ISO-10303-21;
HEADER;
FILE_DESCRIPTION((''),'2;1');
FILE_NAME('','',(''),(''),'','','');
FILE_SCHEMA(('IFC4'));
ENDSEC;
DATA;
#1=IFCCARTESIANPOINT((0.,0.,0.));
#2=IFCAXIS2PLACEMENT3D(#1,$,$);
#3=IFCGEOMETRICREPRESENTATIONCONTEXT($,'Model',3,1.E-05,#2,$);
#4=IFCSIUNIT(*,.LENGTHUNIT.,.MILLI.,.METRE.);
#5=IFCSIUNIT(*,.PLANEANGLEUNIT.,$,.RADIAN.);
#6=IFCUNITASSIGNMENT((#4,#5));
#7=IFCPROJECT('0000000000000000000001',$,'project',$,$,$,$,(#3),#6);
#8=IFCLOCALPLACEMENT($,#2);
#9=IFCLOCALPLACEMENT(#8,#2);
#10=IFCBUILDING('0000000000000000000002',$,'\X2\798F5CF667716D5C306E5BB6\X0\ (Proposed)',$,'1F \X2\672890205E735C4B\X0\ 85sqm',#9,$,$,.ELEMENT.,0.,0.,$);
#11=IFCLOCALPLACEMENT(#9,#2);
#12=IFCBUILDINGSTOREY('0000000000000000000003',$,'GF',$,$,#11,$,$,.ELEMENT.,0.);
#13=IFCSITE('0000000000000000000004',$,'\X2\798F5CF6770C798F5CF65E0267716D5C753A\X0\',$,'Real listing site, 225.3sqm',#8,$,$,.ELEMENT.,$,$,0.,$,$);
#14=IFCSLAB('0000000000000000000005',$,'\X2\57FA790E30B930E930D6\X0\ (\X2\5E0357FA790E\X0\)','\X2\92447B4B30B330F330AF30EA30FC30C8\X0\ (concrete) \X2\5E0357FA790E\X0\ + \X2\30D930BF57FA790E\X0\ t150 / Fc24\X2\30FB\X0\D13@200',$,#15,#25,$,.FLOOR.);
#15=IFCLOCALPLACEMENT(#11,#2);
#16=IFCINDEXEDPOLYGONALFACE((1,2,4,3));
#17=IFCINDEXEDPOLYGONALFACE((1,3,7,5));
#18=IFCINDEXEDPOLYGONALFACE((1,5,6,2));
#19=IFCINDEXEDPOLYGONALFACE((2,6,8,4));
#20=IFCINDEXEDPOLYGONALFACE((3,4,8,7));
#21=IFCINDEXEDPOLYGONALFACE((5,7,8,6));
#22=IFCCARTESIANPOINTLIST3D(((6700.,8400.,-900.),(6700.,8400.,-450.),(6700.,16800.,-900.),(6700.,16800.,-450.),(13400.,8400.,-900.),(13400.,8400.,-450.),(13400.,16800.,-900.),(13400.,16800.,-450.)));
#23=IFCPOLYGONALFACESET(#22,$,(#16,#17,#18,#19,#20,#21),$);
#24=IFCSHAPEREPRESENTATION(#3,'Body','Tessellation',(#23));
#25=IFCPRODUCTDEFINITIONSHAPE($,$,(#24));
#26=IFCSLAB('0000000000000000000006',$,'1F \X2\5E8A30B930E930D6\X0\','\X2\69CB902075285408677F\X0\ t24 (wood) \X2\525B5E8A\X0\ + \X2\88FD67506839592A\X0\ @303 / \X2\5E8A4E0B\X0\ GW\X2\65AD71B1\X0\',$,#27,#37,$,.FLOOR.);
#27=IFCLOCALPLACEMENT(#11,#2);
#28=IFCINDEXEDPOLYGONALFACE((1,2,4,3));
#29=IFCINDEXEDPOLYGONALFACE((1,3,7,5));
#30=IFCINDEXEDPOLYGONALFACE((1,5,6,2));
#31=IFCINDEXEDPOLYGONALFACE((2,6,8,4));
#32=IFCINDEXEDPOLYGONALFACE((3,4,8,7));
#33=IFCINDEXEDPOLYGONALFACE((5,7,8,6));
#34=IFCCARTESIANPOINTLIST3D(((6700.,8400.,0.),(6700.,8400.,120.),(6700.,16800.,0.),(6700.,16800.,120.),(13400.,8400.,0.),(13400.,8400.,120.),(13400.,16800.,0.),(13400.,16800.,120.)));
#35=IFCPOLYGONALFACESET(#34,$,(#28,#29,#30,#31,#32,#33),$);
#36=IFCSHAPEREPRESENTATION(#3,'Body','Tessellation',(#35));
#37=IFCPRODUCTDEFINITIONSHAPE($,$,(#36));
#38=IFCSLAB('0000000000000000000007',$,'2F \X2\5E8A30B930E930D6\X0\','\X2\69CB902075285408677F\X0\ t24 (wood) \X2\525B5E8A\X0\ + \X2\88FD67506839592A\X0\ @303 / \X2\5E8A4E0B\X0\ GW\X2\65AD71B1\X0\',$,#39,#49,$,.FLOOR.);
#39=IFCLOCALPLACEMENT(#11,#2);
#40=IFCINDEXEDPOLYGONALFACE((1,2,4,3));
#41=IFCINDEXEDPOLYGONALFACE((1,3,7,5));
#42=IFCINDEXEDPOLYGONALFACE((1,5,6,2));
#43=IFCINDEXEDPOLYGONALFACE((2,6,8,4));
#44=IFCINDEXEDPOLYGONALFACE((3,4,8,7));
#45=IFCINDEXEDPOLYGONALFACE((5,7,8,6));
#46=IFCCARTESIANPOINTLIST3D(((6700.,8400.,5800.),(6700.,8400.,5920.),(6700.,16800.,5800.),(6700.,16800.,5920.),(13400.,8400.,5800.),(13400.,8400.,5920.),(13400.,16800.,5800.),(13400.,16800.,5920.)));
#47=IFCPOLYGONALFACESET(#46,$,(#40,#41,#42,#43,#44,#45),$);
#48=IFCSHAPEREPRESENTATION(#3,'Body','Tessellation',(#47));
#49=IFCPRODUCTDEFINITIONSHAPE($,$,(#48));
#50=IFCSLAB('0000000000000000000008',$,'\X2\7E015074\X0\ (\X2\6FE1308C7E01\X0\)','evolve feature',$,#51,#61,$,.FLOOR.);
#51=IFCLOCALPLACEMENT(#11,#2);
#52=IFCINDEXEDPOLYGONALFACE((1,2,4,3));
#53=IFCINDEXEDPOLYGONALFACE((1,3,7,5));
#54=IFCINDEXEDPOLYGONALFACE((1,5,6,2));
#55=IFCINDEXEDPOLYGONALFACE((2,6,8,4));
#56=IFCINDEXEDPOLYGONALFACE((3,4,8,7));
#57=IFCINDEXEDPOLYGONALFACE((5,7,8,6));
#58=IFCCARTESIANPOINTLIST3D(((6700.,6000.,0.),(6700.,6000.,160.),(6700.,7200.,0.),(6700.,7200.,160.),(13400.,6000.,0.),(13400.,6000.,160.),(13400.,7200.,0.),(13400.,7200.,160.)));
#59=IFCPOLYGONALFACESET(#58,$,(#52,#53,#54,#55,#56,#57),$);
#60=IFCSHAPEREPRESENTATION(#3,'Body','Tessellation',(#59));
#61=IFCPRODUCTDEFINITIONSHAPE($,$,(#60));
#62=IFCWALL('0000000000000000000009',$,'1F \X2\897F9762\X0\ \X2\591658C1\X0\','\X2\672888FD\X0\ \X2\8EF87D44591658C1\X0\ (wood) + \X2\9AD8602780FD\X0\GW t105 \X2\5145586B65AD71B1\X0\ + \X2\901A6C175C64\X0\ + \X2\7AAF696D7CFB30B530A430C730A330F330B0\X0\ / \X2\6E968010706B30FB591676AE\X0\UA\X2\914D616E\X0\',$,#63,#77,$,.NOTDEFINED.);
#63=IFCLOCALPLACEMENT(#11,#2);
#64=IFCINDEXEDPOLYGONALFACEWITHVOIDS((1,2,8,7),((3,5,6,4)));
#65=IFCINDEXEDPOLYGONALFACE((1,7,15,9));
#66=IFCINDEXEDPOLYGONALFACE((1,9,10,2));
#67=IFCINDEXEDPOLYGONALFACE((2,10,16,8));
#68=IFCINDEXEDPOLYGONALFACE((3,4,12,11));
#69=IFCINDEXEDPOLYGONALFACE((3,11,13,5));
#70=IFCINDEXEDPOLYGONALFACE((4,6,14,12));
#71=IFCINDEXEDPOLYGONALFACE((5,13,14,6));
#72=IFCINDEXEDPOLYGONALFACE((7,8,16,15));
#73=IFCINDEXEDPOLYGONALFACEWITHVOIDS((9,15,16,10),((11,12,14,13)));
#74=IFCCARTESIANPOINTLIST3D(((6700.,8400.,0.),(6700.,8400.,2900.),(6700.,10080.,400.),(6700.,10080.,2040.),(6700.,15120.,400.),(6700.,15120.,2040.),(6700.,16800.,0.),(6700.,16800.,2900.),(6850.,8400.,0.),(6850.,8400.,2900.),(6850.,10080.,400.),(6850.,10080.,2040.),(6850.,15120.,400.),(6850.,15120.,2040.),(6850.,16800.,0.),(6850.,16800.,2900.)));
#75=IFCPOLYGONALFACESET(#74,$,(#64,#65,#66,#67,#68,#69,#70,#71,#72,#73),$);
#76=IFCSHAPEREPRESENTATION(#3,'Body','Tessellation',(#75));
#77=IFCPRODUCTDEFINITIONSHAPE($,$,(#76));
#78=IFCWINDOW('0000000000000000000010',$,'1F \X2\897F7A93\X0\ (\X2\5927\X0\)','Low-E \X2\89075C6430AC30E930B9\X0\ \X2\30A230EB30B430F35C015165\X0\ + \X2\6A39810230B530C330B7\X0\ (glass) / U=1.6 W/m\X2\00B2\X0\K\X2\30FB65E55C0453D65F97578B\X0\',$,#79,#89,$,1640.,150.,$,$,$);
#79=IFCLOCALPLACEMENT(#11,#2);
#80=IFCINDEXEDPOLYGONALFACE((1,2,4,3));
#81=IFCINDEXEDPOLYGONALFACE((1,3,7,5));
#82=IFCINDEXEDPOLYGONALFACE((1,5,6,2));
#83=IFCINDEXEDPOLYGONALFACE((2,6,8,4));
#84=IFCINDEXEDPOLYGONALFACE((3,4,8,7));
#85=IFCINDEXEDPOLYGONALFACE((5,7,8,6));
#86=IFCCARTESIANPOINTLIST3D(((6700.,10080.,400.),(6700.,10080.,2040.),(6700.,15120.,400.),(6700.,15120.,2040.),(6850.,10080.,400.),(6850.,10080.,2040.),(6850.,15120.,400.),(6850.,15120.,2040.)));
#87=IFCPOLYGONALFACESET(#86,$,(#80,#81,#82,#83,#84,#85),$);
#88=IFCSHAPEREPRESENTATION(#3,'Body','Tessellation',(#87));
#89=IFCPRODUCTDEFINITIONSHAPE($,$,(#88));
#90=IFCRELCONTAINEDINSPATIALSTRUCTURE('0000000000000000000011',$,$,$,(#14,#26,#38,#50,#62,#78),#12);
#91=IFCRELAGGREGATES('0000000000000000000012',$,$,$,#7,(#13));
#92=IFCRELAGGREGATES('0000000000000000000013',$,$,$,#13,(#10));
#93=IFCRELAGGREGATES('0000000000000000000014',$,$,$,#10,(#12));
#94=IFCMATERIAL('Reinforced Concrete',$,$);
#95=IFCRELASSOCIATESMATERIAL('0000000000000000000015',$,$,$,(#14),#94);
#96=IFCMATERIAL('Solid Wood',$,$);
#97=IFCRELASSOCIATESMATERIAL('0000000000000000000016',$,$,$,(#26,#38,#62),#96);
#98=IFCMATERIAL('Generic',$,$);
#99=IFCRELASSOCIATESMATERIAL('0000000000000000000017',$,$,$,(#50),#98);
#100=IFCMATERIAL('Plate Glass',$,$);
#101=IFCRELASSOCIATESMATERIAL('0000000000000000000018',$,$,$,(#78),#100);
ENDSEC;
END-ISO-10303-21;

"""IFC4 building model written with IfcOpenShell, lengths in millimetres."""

from ifc_helpers import new_model, si_unit, frame, frame_2d, origin, place, context, project, spatial, rectangle, extrude, material, element, fill, save


model = new_model("IFC4")

# Units and contexts
model_context = context("Model", 3, precision=1e-05, world=origin())
ifc_project = project(units=[si_unit("LENGTHUNIT", "METRE", prefix="MILLI"), si_unit("PLANEANGLEUNIT", "RADIAN")], contexts=[model_context])

# Site, building, storey
site_placement = place(None, origin())
site = spatial("IfcSite", under=ifc_project, at=site_placement, Name="福島県福島市東浜町", ObjectType="Real listing site, 225.3sqm", CompositionType="ELEMENT", RefElevation=0.0)
building_placement = place(site_placement, origin())
building = spatial("IfcBuilding", under=site, at=building_placement, Name="福島東浜の家 (Proposed)", ObjectType="1F 木造平屋 85sqm", CompositionType="ELEMENT", ElevationOfRefHeight=0.0, ElevationOfTerrain=0.0)
storey_placement = place(building_placement, origin())
storey = spatial("IfcBuildingStorey", under=building, at=storey_placement, Name="GF", CompositionType="ELEMENT", Elevation=0.0)

# Slabs
ifc_material_1 = material(Name="Reinforced Concrete")
slab_1_placement = place(storey_placement, frame((3350.0, 4200.0, -450.0)))
element("IfcSlab", 1, at=slab_1_placement, inside=storey, material=ifc_material_1, Name="基礎スラブ (布基礎)", Description="鉄筋コンクリート (concrete) 布基礎 + ベタ基礎 t150 / Fc24・D13@200", PredefinedType="FLOOR", context=model_context, shape_type="SweptSolid", body=[
    extrude(rectangle(XDim=6700.0, YDim=8400.0, at=frame_2d((3350.0, 4200.0))), frame((3350.0, 4200.0, -450.0)), (0.0, 0.0, 1.0), 450.0),
])
ifc_material_2 = material(Name="Solid Wood")
slab_2_placement = place(storey_placement, frame((3350.0, 4200.0, 0.0)))
element("IfcSlab", 2, at=slab_2_placement, inside=storey, material=ifc_material_2, Name="1F 床スラブ", Description="構造用合板 t24 (wood) 剛床 + 製材根太 @303 / 床下 GW断熱", PredefinedType="FLOOR", context=model_context, shape_type="SweptSolid", body=[
    extrude(rectangle(XDim=6700.0, YDim=8400.0, at=frame_2d((3350.0, 4200.0))), frame((3350.0, 4200.0, 0.0)), (0.0, 0.0, 1.0), 120.0),
])
slab_3_placement = place(storey_placement, frame((3350.0, 4200.0, 2900.0)))
element("IfcSlab", 3, at=slab_3_placement, inside=storey, material=ifc_material_2, Name="2F 床スラブ", Description="構造用合板 t24 (wood) 剛床 + 製材根太 @303 / 床下 GW断熱", PredefinedType="FLOOR", context=model_context, shape_type="SweptSolid", body=[
    extrude(rectangle(XDim=6700.0, YDim=8400.0, at=frame_2d((3350.0, 4200.0))), frame((3350.0, 4200.0, 2900.0)), (0.0, 0.0, 1.0), 120.0),
])
ifc_material_3 = material(Name="Generic")
slab_4_placement = place(storey_placement, frame((3350.0, 3000.0, 0.0)))
element("IfcSlab", 4, at=slab_4_placement, inside=storey, material=ifc_material_3, Name="縁側 (濡れ縁)", Description="evolve feature", PredefinedType="FLOOR", context=model_context, shape_type="SweptSolid", body=[
    extrude(rectangle(XDim=6700.0, YDim=1200.0, at=frame_2d((3350.0, 600.0))), frame((3350.0, 3000.0, 0.0)), (0.0, 0.0, 1.0), 160.0),
])

# Shared definitions
ifc_material_4 = material(Name="Plate Glass")

# Wall, opening, window
wall_1_placement = place(storey_placement, frame((3350.0, 4200.0, 0.0)))
wall_1 = element("IfcWall", 5, at=wall_1_placement, inside=storey, material=ifc_material_2, Name="1F 西面 外壁", Description="木製 軸組外壁 (wood) + 高性能GW t105 充填断熱 + 通気層 + 窯業系サイディング / 準耐火・外皮UA配慮", PredefinedType="NOTDEFINED", context=model_context, shape_type="SweptSolid", body=[
    extrude(rectangle(XDim=150.0, YDim=8400.0, at=frame_2d((75.0, 4200.0))), frame((3350.0, 4200.0, 0.0)), (0.0, 0.0, 1.0), 2900.0),
])
opening_1_placement = place(storey_placement, frame((3350.0, 5040.0, 200.0)))
opening_1 = element("IfcOpeningElement", 6, at=opening_1_placement, cuts=wall_1, PredefinedType="NOTDEFINED", context=model_context, shape_type="SweptSolid", body=[
    extrude(rectangle(XDim=150.0, YDim=5040.0, at=frame_2d((75.0, 2520.0))), frame((3350.0, 5040.0, 200.0)), (0.0, 0.0, 1.0), 1640.0),
])
window_1_placement = place(storey_placement, frame((3350.0, 5040.0, 200.0)))
window_1 = element("IfcWindow", 7, at=window_1_placement, inside=storey, material=ifc_material_4, Name="1F 西窓 (大)", Description="Low-E 複層ガラス アルゴン封入 + 樹脂サッシ (glass) / U=1.6 W/m²K・日射取得型", OverallHeight=1640.0, OverallWidth=150.0, context=model_context, shape_type="SweptSolid", body=[
    extrude(rectangle(XDim=150.0, YDim=5040.0, at=frame_2d((75.0, 2520.0))), frame((3350.0, 5040.0, 200.0)), (0.0, 0.0, 1.0), 1640.0),
])
fill(opening_1, window_1)

save(model, "model.ifc")
